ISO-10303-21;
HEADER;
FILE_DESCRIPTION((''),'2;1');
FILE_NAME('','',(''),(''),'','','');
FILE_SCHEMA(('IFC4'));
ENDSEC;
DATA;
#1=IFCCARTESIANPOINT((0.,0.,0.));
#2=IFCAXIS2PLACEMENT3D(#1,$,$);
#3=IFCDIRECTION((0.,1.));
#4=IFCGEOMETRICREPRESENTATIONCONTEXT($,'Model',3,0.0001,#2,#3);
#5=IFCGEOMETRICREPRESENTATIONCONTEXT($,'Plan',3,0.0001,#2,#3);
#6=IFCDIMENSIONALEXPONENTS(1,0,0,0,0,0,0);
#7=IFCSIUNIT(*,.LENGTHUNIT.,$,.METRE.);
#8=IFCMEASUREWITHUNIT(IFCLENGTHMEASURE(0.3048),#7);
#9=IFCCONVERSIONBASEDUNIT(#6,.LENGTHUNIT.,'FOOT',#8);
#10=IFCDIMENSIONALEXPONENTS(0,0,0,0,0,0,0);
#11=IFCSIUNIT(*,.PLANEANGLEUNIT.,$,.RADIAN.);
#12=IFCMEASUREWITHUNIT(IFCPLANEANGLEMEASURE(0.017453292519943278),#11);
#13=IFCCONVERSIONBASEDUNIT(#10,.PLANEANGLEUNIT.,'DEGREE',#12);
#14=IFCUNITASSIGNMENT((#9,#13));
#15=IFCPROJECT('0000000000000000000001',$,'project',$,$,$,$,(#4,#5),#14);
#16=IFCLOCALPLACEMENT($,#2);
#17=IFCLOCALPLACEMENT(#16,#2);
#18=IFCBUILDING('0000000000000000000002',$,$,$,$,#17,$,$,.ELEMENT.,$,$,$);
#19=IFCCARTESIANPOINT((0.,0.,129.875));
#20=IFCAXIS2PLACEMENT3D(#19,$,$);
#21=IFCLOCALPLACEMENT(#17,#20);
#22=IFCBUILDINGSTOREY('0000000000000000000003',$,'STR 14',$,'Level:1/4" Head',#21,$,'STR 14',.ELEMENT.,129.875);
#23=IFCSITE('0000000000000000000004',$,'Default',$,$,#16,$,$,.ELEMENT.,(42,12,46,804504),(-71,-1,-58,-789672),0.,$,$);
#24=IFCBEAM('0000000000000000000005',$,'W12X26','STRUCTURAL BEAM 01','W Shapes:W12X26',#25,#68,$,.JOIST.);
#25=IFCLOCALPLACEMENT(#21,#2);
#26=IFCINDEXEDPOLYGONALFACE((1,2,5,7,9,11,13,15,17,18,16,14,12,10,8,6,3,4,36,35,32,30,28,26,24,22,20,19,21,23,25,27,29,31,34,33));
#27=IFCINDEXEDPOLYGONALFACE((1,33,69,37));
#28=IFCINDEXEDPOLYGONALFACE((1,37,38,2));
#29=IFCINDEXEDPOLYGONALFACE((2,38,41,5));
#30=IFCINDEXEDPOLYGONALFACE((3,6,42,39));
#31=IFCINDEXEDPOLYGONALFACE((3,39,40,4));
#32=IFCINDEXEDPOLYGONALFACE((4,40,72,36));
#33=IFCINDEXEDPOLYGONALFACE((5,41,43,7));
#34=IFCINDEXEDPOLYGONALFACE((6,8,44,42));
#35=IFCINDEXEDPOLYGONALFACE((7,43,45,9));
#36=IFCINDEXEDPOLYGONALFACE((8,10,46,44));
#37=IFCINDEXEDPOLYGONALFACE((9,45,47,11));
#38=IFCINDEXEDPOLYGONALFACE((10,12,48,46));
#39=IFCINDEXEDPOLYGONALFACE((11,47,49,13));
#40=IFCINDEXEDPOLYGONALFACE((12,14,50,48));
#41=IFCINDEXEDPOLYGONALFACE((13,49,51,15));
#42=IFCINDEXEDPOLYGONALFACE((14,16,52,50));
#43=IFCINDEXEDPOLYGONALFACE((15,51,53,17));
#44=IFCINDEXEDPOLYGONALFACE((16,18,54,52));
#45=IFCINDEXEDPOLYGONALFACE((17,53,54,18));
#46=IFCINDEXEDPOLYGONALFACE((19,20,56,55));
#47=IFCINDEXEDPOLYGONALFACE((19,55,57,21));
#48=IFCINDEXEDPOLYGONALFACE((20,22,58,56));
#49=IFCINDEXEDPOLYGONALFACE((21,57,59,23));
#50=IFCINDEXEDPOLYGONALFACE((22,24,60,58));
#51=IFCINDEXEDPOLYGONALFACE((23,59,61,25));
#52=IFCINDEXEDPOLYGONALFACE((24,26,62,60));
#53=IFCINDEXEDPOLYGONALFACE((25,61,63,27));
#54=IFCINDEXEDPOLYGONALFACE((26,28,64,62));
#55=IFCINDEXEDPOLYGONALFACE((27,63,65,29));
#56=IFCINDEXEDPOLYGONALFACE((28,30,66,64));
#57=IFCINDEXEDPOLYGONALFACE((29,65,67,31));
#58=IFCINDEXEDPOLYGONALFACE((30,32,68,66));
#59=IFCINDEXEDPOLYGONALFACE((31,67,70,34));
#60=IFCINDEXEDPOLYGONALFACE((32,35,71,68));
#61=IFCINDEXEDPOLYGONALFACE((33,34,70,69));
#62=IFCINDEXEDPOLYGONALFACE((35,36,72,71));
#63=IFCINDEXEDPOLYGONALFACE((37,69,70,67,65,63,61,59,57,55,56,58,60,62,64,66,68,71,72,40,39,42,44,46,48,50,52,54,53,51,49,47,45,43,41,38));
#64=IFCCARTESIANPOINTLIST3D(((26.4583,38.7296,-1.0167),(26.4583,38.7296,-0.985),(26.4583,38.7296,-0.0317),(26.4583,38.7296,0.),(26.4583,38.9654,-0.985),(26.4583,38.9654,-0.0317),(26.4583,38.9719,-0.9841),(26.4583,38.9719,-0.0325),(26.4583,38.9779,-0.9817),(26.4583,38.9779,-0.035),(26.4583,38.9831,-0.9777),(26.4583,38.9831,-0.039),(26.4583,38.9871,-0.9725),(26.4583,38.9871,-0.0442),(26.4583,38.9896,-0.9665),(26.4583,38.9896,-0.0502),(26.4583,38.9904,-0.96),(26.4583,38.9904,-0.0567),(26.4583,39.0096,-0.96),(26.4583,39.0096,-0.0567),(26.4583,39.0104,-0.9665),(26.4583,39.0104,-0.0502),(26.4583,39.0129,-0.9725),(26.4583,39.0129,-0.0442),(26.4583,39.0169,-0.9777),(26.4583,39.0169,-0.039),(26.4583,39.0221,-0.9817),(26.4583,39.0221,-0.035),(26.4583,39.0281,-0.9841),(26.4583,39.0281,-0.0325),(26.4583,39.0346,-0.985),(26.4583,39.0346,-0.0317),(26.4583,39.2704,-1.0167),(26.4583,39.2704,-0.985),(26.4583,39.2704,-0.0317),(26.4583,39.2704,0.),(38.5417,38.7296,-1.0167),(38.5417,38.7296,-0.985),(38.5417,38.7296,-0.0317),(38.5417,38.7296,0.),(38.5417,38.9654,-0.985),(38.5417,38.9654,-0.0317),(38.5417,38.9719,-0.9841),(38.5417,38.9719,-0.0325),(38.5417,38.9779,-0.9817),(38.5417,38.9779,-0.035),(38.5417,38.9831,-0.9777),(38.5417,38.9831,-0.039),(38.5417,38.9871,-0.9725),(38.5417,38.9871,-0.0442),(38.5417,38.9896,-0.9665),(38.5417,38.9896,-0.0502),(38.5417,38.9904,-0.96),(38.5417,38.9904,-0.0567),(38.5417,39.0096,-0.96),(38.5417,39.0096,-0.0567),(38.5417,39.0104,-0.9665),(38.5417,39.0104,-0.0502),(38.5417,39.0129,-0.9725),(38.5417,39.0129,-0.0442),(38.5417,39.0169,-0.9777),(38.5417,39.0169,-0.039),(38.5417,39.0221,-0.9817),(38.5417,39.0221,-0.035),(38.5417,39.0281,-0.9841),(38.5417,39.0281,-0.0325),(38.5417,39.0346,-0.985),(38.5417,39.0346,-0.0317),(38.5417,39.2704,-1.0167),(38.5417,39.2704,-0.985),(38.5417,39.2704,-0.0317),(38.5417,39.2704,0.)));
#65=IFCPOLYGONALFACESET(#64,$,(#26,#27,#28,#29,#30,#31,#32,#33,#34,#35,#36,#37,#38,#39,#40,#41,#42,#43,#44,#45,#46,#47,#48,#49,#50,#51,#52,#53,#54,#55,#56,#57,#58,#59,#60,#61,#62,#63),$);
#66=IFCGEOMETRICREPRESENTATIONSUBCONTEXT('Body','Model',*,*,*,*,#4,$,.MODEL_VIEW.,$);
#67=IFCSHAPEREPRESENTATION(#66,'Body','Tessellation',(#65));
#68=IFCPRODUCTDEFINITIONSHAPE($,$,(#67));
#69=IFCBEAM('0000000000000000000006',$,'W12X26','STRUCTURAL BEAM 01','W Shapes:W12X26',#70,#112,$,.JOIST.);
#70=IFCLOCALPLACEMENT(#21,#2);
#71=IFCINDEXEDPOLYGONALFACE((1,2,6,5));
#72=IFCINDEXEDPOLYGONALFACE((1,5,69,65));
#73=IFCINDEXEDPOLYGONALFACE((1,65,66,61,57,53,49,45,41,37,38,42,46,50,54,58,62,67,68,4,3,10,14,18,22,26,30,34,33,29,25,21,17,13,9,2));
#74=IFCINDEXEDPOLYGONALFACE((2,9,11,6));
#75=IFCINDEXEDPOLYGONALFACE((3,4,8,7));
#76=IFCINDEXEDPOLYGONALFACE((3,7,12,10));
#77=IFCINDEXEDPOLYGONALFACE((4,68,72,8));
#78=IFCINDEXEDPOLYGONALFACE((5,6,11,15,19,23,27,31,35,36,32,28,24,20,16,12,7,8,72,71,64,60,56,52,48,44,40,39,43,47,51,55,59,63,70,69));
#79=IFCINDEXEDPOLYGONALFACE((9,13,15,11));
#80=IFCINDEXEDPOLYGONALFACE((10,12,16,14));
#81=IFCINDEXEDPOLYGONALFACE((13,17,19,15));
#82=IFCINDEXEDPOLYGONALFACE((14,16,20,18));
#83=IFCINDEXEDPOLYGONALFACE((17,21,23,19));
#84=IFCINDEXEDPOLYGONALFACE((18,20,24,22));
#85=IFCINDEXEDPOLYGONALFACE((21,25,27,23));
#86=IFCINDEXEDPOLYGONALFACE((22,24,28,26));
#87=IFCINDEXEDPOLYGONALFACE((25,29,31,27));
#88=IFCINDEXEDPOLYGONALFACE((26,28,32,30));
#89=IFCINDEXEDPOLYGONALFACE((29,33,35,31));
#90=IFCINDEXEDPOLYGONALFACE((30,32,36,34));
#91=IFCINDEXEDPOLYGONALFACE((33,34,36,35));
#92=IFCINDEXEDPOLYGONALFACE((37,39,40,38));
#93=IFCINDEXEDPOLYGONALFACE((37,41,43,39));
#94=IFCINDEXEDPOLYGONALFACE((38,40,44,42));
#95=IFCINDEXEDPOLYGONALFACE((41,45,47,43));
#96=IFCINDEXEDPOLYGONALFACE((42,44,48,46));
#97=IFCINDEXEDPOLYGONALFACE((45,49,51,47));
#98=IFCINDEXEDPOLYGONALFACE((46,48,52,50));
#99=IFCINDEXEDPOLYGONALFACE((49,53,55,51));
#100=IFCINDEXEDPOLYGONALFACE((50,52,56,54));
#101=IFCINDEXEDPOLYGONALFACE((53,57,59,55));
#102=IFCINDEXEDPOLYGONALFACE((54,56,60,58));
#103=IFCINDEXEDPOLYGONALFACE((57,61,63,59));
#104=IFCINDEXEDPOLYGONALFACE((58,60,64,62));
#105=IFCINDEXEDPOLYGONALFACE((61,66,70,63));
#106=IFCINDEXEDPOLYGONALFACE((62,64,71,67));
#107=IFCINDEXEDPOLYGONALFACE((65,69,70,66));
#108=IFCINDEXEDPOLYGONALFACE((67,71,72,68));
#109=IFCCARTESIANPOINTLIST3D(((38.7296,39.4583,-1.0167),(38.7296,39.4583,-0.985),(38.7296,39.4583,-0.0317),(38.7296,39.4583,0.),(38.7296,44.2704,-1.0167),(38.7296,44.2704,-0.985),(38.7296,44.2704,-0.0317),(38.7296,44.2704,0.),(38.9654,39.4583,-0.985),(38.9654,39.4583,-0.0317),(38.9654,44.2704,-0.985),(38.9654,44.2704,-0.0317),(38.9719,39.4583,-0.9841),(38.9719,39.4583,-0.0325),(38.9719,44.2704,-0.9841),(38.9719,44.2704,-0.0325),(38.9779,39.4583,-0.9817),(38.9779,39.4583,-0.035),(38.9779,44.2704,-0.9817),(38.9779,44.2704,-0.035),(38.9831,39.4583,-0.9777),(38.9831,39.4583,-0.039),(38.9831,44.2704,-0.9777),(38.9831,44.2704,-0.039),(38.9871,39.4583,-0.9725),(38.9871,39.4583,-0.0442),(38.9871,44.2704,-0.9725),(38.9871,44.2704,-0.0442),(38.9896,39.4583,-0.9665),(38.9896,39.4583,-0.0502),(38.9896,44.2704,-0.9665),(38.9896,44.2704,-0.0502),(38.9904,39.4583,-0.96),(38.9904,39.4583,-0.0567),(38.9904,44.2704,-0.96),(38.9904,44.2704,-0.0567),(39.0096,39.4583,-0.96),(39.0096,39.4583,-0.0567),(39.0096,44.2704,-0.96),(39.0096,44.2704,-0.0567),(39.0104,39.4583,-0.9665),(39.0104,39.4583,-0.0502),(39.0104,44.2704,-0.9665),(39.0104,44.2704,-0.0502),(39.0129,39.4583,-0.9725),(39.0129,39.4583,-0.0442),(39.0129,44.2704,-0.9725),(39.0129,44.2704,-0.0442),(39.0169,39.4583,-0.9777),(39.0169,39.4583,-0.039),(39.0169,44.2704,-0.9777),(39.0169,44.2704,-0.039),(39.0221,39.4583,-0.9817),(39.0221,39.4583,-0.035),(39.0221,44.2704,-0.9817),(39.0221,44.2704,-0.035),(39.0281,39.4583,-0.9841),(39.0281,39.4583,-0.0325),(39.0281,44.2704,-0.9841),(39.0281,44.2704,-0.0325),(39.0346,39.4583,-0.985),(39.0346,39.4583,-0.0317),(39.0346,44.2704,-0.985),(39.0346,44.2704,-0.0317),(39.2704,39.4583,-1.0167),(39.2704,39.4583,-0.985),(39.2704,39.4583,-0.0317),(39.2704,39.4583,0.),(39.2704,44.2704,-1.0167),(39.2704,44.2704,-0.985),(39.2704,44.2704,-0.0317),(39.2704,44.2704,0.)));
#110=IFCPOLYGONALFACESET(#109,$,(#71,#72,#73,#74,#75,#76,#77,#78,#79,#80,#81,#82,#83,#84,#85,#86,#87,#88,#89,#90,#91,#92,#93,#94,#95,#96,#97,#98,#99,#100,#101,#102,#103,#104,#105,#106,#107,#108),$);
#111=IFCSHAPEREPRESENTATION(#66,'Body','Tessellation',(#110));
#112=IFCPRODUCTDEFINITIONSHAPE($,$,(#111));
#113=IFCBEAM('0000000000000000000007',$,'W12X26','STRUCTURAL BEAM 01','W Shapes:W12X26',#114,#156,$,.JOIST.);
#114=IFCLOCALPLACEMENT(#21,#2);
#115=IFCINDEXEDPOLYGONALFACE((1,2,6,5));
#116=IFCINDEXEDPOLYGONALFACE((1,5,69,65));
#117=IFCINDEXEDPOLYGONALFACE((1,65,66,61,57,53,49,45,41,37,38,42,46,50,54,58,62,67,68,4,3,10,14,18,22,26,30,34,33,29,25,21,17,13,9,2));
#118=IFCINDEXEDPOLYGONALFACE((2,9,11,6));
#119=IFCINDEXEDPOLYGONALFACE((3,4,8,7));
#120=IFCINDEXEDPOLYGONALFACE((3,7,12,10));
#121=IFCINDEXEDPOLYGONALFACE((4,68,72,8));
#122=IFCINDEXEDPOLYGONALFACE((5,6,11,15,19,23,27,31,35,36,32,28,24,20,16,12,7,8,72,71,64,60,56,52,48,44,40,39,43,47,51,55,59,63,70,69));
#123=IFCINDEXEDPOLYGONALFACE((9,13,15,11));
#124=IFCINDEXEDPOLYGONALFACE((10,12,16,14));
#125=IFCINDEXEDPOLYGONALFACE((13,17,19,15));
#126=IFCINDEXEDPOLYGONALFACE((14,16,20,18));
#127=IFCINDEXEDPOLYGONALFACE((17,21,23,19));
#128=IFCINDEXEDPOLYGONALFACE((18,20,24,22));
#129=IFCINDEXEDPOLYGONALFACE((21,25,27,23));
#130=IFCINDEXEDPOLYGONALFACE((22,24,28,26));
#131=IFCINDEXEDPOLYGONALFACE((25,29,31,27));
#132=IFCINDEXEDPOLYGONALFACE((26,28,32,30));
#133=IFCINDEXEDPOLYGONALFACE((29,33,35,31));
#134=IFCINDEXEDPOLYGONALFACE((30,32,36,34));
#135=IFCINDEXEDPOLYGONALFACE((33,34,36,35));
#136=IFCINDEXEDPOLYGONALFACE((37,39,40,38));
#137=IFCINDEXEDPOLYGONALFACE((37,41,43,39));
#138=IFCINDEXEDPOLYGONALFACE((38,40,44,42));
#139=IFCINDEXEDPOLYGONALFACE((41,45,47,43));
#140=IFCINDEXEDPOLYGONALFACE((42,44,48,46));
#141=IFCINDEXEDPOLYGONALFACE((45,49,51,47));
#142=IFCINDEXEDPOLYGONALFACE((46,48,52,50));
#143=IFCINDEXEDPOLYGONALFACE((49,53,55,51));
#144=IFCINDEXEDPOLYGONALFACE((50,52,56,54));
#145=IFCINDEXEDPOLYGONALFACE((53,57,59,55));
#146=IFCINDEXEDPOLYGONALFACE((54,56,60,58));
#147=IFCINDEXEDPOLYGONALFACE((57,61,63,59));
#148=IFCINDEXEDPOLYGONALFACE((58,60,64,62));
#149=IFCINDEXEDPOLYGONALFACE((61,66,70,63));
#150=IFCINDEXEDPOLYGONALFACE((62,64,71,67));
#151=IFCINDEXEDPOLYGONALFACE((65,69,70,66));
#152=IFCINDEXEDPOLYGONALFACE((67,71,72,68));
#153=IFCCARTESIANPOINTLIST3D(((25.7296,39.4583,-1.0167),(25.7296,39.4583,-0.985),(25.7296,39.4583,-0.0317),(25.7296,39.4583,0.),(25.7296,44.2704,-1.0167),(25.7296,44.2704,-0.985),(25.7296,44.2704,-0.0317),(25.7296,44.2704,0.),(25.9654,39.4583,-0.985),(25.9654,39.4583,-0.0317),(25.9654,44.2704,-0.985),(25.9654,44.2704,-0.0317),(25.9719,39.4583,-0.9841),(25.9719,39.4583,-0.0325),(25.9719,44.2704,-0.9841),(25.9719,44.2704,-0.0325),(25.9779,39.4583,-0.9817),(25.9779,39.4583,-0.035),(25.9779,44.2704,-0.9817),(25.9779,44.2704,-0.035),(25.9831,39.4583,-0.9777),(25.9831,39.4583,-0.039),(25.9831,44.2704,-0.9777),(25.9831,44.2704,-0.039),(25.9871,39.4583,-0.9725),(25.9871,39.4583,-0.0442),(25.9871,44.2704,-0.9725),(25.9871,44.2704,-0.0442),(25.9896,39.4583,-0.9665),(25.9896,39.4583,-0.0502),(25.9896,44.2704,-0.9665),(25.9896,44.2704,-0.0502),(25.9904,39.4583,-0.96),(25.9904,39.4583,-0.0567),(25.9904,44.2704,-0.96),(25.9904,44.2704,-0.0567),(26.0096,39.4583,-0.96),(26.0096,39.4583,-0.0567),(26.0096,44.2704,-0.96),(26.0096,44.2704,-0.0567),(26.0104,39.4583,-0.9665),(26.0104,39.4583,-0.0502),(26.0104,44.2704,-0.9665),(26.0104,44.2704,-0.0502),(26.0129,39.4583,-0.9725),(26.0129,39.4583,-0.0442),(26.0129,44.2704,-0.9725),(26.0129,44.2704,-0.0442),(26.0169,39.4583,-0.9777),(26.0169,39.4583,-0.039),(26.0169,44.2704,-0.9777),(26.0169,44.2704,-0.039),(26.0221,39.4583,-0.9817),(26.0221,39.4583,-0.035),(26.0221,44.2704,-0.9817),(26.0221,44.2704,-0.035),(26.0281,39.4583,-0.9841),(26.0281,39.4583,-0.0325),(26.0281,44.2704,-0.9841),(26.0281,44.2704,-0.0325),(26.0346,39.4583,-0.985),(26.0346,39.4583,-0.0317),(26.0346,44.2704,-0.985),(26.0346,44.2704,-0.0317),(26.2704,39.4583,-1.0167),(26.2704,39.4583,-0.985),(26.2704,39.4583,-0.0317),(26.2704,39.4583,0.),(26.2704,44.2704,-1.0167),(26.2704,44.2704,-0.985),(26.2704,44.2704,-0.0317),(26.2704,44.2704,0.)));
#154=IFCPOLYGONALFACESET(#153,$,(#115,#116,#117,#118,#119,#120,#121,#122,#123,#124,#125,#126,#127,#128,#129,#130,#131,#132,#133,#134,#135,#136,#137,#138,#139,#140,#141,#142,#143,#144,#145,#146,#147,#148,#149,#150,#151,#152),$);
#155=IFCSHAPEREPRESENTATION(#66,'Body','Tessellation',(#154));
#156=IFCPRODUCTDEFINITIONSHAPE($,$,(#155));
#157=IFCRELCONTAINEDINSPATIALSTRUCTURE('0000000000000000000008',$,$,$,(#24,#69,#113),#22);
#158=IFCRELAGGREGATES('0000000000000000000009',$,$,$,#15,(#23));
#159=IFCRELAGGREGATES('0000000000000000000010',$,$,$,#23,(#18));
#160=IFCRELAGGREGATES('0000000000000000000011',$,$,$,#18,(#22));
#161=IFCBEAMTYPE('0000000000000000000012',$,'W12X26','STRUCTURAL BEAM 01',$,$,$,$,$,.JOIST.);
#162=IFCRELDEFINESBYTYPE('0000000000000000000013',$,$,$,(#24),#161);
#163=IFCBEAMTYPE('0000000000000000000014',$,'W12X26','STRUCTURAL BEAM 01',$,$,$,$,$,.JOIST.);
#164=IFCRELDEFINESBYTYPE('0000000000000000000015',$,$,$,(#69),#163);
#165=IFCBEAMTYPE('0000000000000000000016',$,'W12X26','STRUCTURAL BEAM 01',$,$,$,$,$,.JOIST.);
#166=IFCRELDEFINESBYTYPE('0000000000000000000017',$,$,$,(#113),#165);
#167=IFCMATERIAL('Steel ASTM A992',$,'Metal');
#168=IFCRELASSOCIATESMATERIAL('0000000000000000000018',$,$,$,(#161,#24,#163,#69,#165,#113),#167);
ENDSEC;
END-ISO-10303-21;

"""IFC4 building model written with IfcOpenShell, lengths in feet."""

from ifc_helpers import new_model, entity, si_unit, converted_unit, direction, frame, origin, place, context, subcontext, project, spatial, line, arc, indexed_curve, outline, extrude, source, transform, mapped, material, type_object, type_shapes, element, save


model = new_model("IFC4")

# Units and contexts
model_context = context("Model", 3, precision=0.0001, world=origin(), true_north=direction((0.0, 1.0)))
plan_context = context("Plan", 3, precision=0.0001, world=origin(), true_north=direction((0.0, 1.0)))
body_context = subcontext(model_context, "Body", "Model", "MODEL_VIEW")
ifc_project = project(units=[converted_unit("LENGTHUNIT", "FOOT", entity("IfcLengthMeasure", 0.3048), si_unit("LENGTHUNIT", "METRE"), dimensions=[1, 0, 0, 0, 0, 0, 0]), converted_unit("PLANEANGLEUNIT", "DEGREE", entity("IfcPlaneAngleMeasure", 0.017453292519943278), si_unit("PLANEANGLEUNIT", "RADIAN"), dimensions=[0, 0, 0, 0, 0, 0, 0])], contexts=[model_context, plan_context])

# Site, building, storey
site_placement = place(None, origin())
site = spatial("IfcSite", under=ifc_project, at=site_placement, Name="Default", CompositionType="ELEMENT", RefLatitude=(42, 12, 46, 804504), RefLongitude=(-71, -1, -58, -789672), RefElevation=0.0)
building_placement = place(site_placement, origin())
building = spatial("IfcBuilding", under=site, at=building_placement, CompositionType="ELEMENT")
storey_placement = place(building_placement, frame((0.0, 0.0, 129.875)))
storey = spatial("IfcBuildingStorey", under=building, at=storey_placement, Name="STR 14", ObjectType="Level:1/4\" Head", LongName="STR 14", CompositionType="ELEMENT", Elevation=129.875)

# Shared definitions
ifc_material = material(Name="Steel ASTM A992", Category="Metal")

# Beams
beam_type_1 = type_object("IfcBeamType", Name="W12X26", Description="STRUCTURAL BEAM 01", PredefinedType="JOIST", material=ifc_material)
shared_shape_1 = source(origin(), body_context, "Body", "SweptSolid", [
    extrude(outline(indexed_curve([(-0.2704, -0.4767), (-0.2704, -0.5083), (0.2704, -0.5083), (0.2704, -0.4767), (0.0346, -0.4767), (0.0169, -0.4693), (0.0096, -0.4517), (0.0096, 0.4517), (0.0169, 0.4693), (0.0346, 0.4767), (0.2704, 0.4767), (0.2704, 0.5083), (-0.2704, 0.5083), (-0.2704, 0.4767), (-0.0346, 0.4767), (-0.0169, 0.4693), (-0.0096, 0.4517), (-0.0096, -0.4517), (-0.0169, -0.4693), (-0.0346, -0.4767)], segments=[line(1, 2, 3, 4, 5), arc(5, 6, 7), line(7, 8), arc(8, 9, 10), line(10, 11, 12, 13, 14, 15), arc(15, 16, 17), line(17, 18), arc(18, 19, 20), line(20, 1)], self_intersect=False)), frame((-6.0512, 0.0, 0.0), z_axis=(-1.0, 0.0, 0.0), x_axis=(0.0, -1.0, 0.0)), (0.0, 0.0, -1.0), 12.0833),
])
type_shapes(beam_type_1, [shared_shape_1])
for number, where, name in (
    (1, (32.5096, 39.0, -0.5083), "W12X26"),
):
    element("IfcBeam", number, at=place(storey_placement, frame(where)), inside=storey, type_object=beam_type_1, material=ifc_material, Name=name, Description="STRUCTURAL BEAM 01", ObjectType="W Shapes:W12X26", PredefinedType="JOIST", context=body_context, shape_type="MappedRepresentation", body=[
        mapped(shared_shape_1, transform((0.0, 0.0, 0.0), scale=1.0)),
    ])
beam_type_2 = type_object("IfcBeamType", Name="W12X26", Description="STRUCTURAL BEAM 01", PredefinedType="JOIST", material=ifc_material)
shared_shape_2 = source(origin(), body_context, "Body", "SweptSolid", [
    extrude(outline(indexed_curve([(-0.2704, -0.5083), (0.2704, -0.5083), (0.2704, -0.4767), (0.0346, -0.4767), (0.0169, -0.4693), (0.0096, -0.4517), (0.0096, 0.4517), (0.0169, 0.4693), (0.0346, 0.4767), (0.2704, 0.4767), (0.2704, 0.5083), (-0.2704, 0.5083), (-0.2704, 0.4767), (-0.0346, 0.4767), (-0.0169, 0.4693), (-0.0096, 0.4517), (-0.0096, -0.4517), (-0.0169, -0.4693), (-0.0346, -0.4767), (-0.2704, -0.4767)], segments=[line(1, 2, 3, 4), arc(4, 5, 6), line(6, 7), arc(7, 8, 9), line(9, 10, 11, 12, 13, 14), arc(14, 15, 16), line(16, 17), arc(17, 18, 19), line(19, 20, 1)], self_intersect=False)), frame((39.0, 44.2704, 129.3667), z_axis=(0.0, -1.0, 0.0), x_axis=(-1.0, 0.0, 0.0)), (0.0, 0.0, 1.0), 4.8121),
])
type_shapes(beam_type_2, [shared_shape_2])
beam_1_placement = place(storey_placement, frame((0.0, 0.0, -129.875)))
element("IfcBeam", 2, at=beam_1_placement, inside=storey, type_object=beam_type_2, material=ifc_material, Name="W12X26", Description="STRUCTURAL BEAM 01", ObjectType="W Shapes:W12X26", PredefinedType="JOIST", context=body_context, shape_type="MappedRepresentation", body=[
    mapped(shared_shape_2, transform((0.0, 0.0, 0.0), scale=1.0)),
])
beam_type_3 = type_object("IfcBeamType", Name="W12X26", Description="STRUCTURAL BEAM 01", PredefinedType="JOIST", material=ifc_material)
shared_shape_3 = source(origin(), body_context, "Body", "SweptSolid", [
    extrude(outline(indexed_curve([(-0.2704, -0.5083), (0.2704, -0.5083), (0.2704, -0.4767), (0.0346, -0.4767), (0.0169, -0.4693), (0.0096, -0.4517), (0.0096, 0.4517), (0.0169, 0.4693), (0.0346, 0.4767), (0.2704, 0.4767), (0.2704, 0.5083), (-0.2704, 0.5083), (-0.2704, 0.4767), (-0.0346, 0.4767), (-0.0169, 0.4693), (-0.0096, 0.4517), (-0.0096, -0.4517), (-0.0169, -0.4693), (-0.0346, -0.4767), (-0.2704, -0.4767)], segments=[line(1, 2, 3, 4), arc(4, 5, 6), line(6, 7), arc(7, 8, 9), line(9, 10, 11, 12, 13, 14), arc(14, 15, 16), line(16, 17), arc(17, 18, 19), line(19, 20, 1)], self_intersect=False)), frame((26.0, 44.2704, 129.3667), z_axis=(0.0, -1.0, 0.0), x_axis=(-1.0, 0.0, 0.0)), (0.0, 0.0, 1.0), 4.8121),
])
type_shapes(beam_type_3, [shared_shape_3])
beam_2_placement = place(storey_placement, frame((0.0, 0.0, -129.875)))
element("IfcBeam", 3, at=beam_2_placement, inside=storey, type_object=beam_type_3, material=ifc_material, Name="W12X26", Description="STRUCTURAL BEAM 01", ObjectType="W Shapes:W12X26", PredefinedType="JOIST", context=body_context, shape_type="MappedRepresentation", body=[
    mapped(shared_shape_3, transform((0.0, 0.0, 0.0), scale=1.0)),
])

save(model, "model.ifc")
